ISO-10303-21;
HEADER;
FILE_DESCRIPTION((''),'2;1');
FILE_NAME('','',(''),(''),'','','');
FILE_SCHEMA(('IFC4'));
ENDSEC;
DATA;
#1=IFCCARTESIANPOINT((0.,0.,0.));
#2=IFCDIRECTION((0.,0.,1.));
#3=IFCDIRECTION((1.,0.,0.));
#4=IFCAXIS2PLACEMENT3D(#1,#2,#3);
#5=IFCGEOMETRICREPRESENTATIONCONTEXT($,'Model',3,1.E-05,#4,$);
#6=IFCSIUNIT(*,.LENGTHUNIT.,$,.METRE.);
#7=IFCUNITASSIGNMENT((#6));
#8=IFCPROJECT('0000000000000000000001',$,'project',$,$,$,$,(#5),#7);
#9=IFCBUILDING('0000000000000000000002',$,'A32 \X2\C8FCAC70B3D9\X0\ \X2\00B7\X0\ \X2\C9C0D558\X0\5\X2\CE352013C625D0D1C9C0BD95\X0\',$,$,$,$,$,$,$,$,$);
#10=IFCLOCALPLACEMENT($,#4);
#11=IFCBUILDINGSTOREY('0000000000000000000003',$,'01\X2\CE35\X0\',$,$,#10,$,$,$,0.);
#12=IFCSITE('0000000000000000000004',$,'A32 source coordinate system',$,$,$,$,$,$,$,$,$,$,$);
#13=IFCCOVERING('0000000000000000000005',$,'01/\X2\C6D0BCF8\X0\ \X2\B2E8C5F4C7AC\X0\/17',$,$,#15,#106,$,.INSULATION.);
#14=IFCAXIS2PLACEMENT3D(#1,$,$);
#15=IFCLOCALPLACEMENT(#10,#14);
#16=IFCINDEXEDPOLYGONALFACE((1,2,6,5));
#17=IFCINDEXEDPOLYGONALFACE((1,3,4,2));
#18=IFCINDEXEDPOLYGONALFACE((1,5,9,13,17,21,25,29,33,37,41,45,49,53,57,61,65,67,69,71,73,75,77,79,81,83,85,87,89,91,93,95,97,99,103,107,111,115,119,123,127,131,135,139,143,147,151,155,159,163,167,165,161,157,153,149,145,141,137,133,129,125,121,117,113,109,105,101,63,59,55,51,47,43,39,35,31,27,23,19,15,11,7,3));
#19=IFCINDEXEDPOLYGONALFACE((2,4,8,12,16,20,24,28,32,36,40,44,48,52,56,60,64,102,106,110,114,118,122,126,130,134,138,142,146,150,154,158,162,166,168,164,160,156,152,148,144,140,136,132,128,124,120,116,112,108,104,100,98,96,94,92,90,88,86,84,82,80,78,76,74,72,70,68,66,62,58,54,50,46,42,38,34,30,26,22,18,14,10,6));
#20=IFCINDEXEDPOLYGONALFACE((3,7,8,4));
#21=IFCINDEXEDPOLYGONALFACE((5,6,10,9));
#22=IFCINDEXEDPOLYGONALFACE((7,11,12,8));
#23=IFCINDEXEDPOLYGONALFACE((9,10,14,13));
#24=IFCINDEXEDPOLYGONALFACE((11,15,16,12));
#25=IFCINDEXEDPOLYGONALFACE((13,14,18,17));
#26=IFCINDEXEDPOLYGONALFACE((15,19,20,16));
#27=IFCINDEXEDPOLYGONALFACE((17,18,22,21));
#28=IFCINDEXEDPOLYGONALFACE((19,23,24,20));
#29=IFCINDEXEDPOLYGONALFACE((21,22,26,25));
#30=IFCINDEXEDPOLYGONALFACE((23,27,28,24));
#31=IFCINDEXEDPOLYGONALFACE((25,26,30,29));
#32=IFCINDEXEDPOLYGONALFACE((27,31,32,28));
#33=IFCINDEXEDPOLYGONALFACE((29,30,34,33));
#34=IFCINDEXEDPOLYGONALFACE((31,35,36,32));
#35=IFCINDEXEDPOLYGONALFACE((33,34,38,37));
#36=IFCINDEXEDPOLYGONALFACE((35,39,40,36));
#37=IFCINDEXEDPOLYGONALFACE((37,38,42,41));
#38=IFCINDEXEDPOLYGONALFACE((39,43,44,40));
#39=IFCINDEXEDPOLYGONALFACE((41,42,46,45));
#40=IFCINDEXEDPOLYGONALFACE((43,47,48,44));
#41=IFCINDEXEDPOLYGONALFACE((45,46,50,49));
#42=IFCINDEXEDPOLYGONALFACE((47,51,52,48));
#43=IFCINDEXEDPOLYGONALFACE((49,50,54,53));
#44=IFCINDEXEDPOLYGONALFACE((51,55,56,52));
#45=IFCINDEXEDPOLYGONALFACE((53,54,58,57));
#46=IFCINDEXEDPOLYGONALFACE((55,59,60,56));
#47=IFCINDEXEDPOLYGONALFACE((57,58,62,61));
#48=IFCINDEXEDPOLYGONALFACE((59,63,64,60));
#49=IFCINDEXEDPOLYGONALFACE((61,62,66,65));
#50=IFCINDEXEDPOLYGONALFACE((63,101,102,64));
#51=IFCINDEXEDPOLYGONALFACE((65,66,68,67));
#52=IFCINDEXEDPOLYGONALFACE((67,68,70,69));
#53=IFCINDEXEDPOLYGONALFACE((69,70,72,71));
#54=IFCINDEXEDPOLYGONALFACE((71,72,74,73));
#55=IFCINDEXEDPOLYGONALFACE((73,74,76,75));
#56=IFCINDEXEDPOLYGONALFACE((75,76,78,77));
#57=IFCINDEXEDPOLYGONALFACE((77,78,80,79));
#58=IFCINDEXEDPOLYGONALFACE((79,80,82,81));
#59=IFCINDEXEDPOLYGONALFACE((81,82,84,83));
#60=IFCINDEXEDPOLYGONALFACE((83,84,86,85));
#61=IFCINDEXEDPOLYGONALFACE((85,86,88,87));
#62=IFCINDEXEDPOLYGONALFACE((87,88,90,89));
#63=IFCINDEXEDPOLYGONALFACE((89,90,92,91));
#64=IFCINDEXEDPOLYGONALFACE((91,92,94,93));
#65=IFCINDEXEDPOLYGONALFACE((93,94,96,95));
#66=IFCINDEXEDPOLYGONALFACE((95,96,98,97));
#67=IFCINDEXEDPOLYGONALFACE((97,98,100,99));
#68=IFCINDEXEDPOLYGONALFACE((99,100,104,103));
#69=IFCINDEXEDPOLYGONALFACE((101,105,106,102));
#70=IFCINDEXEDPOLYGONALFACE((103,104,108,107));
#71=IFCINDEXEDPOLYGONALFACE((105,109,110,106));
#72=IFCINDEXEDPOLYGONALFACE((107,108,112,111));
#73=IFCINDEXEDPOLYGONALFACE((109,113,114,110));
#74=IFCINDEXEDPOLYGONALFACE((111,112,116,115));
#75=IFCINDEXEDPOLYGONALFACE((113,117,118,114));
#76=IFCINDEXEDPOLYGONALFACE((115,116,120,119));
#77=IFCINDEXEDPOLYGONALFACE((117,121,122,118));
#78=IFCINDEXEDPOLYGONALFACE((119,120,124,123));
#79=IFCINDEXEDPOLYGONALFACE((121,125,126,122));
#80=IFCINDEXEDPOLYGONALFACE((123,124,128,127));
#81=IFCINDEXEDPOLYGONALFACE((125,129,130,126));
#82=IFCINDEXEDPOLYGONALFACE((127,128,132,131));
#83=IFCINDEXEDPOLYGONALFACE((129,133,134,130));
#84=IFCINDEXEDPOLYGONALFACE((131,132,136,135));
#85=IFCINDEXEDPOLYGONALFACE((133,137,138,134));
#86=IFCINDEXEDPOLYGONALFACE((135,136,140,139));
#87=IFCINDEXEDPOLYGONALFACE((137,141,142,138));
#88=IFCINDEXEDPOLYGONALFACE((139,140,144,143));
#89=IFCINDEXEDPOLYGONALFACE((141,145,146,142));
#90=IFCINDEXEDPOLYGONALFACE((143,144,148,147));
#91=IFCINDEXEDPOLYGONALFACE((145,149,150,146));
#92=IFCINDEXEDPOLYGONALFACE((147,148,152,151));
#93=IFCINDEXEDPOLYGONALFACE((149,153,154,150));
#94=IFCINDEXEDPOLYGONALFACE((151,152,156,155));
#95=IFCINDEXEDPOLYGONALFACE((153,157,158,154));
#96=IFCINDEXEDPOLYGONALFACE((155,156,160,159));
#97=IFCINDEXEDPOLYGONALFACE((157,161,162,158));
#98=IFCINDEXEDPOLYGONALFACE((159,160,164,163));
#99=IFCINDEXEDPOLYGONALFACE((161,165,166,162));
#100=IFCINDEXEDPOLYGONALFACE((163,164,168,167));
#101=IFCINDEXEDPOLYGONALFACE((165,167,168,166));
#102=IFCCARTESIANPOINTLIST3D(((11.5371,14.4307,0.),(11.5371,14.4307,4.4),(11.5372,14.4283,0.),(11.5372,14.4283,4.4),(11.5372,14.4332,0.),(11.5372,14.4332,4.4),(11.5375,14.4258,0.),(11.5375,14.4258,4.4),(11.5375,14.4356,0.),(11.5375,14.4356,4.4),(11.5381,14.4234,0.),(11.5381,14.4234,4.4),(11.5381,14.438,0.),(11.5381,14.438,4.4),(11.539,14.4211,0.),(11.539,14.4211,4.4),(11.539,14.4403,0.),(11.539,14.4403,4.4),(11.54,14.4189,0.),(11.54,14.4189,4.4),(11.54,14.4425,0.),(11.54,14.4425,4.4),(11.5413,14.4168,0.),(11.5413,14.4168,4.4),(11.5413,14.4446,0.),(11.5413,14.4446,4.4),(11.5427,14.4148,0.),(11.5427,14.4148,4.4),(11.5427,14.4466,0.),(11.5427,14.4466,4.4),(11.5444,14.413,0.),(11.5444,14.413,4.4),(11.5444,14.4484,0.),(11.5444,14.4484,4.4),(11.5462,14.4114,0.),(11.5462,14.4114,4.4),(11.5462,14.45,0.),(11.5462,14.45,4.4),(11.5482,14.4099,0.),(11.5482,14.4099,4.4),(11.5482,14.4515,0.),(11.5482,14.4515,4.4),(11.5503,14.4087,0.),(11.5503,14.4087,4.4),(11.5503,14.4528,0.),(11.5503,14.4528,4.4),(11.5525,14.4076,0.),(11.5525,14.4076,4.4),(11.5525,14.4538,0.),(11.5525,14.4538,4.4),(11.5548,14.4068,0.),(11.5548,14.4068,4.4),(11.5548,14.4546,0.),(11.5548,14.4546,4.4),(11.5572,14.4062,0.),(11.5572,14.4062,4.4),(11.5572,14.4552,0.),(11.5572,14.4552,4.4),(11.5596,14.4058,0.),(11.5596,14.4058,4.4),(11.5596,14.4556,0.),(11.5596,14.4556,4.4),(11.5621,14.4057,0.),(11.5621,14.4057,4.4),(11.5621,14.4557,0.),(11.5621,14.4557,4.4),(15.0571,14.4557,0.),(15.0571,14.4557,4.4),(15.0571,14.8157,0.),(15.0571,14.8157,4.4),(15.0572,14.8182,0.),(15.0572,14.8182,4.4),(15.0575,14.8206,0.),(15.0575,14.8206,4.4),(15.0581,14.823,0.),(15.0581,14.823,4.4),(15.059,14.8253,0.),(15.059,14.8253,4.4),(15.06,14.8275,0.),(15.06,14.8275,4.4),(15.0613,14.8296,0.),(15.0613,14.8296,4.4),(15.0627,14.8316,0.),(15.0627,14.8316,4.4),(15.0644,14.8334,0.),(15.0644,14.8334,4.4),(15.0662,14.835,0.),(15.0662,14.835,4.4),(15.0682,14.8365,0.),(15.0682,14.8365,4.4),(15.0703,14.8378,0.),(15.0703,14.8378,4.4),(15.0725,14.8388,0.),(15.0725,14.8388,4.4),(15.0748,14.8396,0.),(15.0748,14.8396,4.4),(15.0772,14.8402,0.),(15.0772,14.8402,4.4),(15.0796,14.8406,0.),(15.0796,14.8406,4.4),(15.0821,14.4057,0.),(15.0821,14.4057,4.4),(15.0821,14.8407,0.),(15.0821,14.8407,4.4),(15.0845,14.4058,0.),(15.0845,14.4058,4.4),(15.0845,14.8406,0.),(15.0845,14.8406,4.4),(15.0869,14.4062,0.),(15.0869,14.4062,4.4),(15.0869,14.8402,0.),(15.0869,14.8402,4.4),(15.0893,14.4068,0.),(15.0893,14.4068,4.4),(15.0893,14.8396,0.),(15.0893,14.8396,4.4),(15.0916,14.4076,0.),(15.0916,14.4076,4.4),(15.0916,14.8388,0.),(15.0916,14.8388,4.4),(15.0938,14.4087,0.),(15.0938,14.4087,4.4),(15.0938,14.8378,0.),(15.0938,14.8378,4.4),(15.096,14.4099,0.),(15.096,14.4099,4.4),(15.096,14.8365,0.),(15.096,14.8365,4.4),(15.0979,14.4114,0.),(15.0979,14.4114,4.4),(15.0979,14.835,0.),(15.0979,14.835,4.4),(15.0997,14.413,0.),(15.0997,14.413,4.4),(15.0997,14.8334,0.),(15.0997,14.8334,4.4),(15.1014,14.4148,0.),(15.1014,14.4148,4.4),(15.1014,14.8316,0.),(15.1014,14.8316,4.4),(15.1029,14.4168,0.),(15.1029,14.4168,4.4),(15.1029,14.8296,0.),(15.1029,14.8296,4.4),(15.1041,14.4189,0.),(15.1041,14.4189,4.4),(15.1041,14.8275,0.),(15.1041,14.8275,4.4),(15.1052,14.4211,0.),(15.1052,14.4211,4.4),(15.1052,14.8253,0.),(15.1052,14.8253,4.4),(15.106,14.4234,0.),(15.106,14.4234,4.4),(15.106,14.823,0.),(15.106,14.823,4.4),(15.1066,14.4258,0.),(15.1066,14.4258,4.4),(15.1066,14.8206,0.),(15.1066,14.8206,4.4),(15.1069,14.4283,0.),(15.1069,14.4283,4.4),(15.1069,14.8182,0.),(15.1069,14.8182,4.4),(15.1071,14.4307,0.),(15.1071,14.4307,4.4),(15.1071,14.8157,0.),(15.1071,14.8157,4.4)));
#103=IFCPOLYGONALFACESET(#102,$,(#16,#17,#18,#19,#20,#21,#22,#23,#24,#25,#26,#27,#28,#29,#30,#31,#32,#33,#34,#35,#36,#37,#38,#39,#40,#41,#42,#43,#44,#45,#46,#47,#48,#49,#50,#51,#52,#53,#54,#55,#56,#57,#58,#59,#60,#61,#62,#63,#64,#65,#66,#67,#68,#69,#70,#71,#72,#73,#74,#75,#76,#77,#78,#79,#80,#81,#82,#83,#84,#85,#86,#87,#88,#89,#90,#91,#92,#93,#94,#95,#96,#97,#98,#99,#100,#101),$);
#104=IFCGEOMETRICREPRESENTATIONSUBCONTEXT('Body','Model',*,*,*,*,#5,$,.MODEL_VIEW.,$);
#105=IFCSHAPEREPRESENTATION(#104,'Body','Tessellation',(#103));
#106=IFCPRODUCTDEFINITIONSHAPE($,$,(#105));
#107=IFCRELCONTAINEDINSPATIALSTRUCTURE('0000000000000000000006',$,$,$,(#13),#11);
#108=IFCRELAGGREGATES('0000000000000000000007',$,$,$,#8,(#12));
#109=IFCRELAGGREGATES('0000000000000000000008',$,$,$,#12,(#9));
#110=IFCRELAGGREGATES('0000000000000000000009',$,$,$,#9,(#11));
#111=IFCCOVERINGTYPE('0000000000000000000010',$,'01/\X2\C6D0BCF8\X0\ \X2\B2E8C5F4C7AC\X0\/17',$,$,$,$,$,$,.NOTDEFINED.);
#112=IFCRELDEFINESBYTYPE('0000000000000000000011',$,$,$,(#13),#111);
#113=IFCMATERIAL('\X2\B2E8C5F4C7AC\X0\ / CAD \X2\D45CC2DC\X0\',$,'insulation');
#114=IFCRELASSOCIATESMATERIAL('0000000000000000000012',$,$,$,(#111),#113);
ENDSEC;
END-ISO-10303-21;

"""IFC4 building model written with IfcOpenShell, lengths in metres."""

from ifc_helpers import new_model, si_unit, origin, origin_with_axes, place, context, subcontext, project, spatial, polyline, outline, extrude, source, transform, mapped, material, type_object, type_shapes, element, save


model = new_model("IFC4")

# Units and contexts
model_context = context("Model", 3, precision=1e-05, world=origin_with_axes())
body_context = subcontext(model_context, "Body", "Model", "MODEL_VIEW")
ifc_project = project(units=[si_unit("LENGTHUNIT", "METRE")], contexts=[model_context])

# Site, building, storey
site = spatial("IfcSite", under=ifc_project, Name="A32 source coordinate system")
building = spatial("IfcBuilding", under=site, Name="A32 주거동 · 지하5층–옥탑지붕")
storey_placement = place(None, origin_with_axes())
storey = spatial("IfcBuildingStorey", under=building, at=storey_placement, Name="01층", Elevation=0.0)

# Covering
ifc_material = material(Name="단열재 / CAD 표시", Category="insulation")
covering_type_1 = type_object("IfcCoveringType", Name="01/원본 단열재/17", PredefinedType="NOTDEFINED", material=ifc_material)
shared_shape_1 = source(origin(), body_context, "Body", "SweptSolid", [
    extrude(outline(polyline([(15.06, 14.8275), (15.0613, 14.8296), (15.0627, 14.8316), (15.0644, 14.8334), (15.0662, 14.835), (15.0682, 14.8365), (15.0703, 14.8378), (15.0725, 14.8388), (15.0748, 14.8396), (15.0772, 14.8402), (15.0796, 14.8406), (15.0821, 14.8407), (15.0845, 14.8406), (15.0869, 14.8402), (15.0893, 14.8396), (15.0916, 14.8388), (15.0938, 14.8378), (15.096, 14.8365), (15.0979, 14.835), (15.0997, 14.8334), (15.1014, 14.8316), (15.1029, 14.8296), (15.1041, 14.8275), (15.1052, 14.8253), (15.106, 14.823), (15.1066, 14.8206), (15.1069, 14.8182), (15.1071, 14.8157), (15.1071, 14.4307), (15.1069, 14.4283), (15.1066, 14.4258), (15.106, 14.4234), (15.1052, 14.4211), (15.1041, 14.4189), (15.1029, 14.4168), (15.1014, 14.4148), (15.0997, 14.413), (15.0979, 14.4114), (15.096, 14.4099), (15.0938, 14.4087), (15.0916, 14.4076), (15.0893, 14.4068), (15.0869, 14.4062), (15.0845, 14.4058), (15.0821, 14.4057), (11.5621, 14.4057), (11.5596, 14.4058), (11.5572, 14.4062), (11.5548, 14.4068), (11.5525, 14.4076), (11.5503, 14.4087), (11.5482, 14.4099), (11.5462, 14.4114), (11.5444, 14.413), (11.5427, 14.4148), (11.5413, 14.4168), (11.54, 14.4189), (11.539, 14.4211), (11.5381, 14.4234), (11.5375, 14.4258), (11.5372, 14.4283), (11.5371, 14.4307), (11.5372, 14.4332), (11.5375, 14.4356), (11.5381, 14.438), (11.539, 14.4403), (11.54, 14.4425), (11.5413, 14.4446), (11.5427, 14.4466), (11.5444, 14.4484), (11.5462, 14.45), (11.5482, 14.4515), (11.5503, 14.4528), (11.5525, 14.4538), (11.5548, 14.4546), (11.5572, 14.4552), (11.5596, 14.4556), (11.5621, 14.4557), (15.0571, 14.4557), (15.0571, 14.8157), (15.0572, 14.8182), (15.0575, 14.8206), (15.0581, 14.823), (15.059, 14.8253), (15.06, 14.8275)])), origin(), (0.0, 0.0, 1.0), 4.4),
])
type_shapes(covering_type_1, [shared_shape_1])
covering_1_placement = place(storey_placement, origin_with_axes())
element("IfcCovering", 1, at=covering_1_placement, inside=storey, type_object=covering_type_1, Name="01/원본 단열재/17", PredefinedType="INSULATION", context=body_context, shape_type="MappedRepresentation", body=[
    mapped(shared_shape_1, transform((0.0, 0.0, 0.0), scale=1.0)),
])

save(model, "model.ifc")
